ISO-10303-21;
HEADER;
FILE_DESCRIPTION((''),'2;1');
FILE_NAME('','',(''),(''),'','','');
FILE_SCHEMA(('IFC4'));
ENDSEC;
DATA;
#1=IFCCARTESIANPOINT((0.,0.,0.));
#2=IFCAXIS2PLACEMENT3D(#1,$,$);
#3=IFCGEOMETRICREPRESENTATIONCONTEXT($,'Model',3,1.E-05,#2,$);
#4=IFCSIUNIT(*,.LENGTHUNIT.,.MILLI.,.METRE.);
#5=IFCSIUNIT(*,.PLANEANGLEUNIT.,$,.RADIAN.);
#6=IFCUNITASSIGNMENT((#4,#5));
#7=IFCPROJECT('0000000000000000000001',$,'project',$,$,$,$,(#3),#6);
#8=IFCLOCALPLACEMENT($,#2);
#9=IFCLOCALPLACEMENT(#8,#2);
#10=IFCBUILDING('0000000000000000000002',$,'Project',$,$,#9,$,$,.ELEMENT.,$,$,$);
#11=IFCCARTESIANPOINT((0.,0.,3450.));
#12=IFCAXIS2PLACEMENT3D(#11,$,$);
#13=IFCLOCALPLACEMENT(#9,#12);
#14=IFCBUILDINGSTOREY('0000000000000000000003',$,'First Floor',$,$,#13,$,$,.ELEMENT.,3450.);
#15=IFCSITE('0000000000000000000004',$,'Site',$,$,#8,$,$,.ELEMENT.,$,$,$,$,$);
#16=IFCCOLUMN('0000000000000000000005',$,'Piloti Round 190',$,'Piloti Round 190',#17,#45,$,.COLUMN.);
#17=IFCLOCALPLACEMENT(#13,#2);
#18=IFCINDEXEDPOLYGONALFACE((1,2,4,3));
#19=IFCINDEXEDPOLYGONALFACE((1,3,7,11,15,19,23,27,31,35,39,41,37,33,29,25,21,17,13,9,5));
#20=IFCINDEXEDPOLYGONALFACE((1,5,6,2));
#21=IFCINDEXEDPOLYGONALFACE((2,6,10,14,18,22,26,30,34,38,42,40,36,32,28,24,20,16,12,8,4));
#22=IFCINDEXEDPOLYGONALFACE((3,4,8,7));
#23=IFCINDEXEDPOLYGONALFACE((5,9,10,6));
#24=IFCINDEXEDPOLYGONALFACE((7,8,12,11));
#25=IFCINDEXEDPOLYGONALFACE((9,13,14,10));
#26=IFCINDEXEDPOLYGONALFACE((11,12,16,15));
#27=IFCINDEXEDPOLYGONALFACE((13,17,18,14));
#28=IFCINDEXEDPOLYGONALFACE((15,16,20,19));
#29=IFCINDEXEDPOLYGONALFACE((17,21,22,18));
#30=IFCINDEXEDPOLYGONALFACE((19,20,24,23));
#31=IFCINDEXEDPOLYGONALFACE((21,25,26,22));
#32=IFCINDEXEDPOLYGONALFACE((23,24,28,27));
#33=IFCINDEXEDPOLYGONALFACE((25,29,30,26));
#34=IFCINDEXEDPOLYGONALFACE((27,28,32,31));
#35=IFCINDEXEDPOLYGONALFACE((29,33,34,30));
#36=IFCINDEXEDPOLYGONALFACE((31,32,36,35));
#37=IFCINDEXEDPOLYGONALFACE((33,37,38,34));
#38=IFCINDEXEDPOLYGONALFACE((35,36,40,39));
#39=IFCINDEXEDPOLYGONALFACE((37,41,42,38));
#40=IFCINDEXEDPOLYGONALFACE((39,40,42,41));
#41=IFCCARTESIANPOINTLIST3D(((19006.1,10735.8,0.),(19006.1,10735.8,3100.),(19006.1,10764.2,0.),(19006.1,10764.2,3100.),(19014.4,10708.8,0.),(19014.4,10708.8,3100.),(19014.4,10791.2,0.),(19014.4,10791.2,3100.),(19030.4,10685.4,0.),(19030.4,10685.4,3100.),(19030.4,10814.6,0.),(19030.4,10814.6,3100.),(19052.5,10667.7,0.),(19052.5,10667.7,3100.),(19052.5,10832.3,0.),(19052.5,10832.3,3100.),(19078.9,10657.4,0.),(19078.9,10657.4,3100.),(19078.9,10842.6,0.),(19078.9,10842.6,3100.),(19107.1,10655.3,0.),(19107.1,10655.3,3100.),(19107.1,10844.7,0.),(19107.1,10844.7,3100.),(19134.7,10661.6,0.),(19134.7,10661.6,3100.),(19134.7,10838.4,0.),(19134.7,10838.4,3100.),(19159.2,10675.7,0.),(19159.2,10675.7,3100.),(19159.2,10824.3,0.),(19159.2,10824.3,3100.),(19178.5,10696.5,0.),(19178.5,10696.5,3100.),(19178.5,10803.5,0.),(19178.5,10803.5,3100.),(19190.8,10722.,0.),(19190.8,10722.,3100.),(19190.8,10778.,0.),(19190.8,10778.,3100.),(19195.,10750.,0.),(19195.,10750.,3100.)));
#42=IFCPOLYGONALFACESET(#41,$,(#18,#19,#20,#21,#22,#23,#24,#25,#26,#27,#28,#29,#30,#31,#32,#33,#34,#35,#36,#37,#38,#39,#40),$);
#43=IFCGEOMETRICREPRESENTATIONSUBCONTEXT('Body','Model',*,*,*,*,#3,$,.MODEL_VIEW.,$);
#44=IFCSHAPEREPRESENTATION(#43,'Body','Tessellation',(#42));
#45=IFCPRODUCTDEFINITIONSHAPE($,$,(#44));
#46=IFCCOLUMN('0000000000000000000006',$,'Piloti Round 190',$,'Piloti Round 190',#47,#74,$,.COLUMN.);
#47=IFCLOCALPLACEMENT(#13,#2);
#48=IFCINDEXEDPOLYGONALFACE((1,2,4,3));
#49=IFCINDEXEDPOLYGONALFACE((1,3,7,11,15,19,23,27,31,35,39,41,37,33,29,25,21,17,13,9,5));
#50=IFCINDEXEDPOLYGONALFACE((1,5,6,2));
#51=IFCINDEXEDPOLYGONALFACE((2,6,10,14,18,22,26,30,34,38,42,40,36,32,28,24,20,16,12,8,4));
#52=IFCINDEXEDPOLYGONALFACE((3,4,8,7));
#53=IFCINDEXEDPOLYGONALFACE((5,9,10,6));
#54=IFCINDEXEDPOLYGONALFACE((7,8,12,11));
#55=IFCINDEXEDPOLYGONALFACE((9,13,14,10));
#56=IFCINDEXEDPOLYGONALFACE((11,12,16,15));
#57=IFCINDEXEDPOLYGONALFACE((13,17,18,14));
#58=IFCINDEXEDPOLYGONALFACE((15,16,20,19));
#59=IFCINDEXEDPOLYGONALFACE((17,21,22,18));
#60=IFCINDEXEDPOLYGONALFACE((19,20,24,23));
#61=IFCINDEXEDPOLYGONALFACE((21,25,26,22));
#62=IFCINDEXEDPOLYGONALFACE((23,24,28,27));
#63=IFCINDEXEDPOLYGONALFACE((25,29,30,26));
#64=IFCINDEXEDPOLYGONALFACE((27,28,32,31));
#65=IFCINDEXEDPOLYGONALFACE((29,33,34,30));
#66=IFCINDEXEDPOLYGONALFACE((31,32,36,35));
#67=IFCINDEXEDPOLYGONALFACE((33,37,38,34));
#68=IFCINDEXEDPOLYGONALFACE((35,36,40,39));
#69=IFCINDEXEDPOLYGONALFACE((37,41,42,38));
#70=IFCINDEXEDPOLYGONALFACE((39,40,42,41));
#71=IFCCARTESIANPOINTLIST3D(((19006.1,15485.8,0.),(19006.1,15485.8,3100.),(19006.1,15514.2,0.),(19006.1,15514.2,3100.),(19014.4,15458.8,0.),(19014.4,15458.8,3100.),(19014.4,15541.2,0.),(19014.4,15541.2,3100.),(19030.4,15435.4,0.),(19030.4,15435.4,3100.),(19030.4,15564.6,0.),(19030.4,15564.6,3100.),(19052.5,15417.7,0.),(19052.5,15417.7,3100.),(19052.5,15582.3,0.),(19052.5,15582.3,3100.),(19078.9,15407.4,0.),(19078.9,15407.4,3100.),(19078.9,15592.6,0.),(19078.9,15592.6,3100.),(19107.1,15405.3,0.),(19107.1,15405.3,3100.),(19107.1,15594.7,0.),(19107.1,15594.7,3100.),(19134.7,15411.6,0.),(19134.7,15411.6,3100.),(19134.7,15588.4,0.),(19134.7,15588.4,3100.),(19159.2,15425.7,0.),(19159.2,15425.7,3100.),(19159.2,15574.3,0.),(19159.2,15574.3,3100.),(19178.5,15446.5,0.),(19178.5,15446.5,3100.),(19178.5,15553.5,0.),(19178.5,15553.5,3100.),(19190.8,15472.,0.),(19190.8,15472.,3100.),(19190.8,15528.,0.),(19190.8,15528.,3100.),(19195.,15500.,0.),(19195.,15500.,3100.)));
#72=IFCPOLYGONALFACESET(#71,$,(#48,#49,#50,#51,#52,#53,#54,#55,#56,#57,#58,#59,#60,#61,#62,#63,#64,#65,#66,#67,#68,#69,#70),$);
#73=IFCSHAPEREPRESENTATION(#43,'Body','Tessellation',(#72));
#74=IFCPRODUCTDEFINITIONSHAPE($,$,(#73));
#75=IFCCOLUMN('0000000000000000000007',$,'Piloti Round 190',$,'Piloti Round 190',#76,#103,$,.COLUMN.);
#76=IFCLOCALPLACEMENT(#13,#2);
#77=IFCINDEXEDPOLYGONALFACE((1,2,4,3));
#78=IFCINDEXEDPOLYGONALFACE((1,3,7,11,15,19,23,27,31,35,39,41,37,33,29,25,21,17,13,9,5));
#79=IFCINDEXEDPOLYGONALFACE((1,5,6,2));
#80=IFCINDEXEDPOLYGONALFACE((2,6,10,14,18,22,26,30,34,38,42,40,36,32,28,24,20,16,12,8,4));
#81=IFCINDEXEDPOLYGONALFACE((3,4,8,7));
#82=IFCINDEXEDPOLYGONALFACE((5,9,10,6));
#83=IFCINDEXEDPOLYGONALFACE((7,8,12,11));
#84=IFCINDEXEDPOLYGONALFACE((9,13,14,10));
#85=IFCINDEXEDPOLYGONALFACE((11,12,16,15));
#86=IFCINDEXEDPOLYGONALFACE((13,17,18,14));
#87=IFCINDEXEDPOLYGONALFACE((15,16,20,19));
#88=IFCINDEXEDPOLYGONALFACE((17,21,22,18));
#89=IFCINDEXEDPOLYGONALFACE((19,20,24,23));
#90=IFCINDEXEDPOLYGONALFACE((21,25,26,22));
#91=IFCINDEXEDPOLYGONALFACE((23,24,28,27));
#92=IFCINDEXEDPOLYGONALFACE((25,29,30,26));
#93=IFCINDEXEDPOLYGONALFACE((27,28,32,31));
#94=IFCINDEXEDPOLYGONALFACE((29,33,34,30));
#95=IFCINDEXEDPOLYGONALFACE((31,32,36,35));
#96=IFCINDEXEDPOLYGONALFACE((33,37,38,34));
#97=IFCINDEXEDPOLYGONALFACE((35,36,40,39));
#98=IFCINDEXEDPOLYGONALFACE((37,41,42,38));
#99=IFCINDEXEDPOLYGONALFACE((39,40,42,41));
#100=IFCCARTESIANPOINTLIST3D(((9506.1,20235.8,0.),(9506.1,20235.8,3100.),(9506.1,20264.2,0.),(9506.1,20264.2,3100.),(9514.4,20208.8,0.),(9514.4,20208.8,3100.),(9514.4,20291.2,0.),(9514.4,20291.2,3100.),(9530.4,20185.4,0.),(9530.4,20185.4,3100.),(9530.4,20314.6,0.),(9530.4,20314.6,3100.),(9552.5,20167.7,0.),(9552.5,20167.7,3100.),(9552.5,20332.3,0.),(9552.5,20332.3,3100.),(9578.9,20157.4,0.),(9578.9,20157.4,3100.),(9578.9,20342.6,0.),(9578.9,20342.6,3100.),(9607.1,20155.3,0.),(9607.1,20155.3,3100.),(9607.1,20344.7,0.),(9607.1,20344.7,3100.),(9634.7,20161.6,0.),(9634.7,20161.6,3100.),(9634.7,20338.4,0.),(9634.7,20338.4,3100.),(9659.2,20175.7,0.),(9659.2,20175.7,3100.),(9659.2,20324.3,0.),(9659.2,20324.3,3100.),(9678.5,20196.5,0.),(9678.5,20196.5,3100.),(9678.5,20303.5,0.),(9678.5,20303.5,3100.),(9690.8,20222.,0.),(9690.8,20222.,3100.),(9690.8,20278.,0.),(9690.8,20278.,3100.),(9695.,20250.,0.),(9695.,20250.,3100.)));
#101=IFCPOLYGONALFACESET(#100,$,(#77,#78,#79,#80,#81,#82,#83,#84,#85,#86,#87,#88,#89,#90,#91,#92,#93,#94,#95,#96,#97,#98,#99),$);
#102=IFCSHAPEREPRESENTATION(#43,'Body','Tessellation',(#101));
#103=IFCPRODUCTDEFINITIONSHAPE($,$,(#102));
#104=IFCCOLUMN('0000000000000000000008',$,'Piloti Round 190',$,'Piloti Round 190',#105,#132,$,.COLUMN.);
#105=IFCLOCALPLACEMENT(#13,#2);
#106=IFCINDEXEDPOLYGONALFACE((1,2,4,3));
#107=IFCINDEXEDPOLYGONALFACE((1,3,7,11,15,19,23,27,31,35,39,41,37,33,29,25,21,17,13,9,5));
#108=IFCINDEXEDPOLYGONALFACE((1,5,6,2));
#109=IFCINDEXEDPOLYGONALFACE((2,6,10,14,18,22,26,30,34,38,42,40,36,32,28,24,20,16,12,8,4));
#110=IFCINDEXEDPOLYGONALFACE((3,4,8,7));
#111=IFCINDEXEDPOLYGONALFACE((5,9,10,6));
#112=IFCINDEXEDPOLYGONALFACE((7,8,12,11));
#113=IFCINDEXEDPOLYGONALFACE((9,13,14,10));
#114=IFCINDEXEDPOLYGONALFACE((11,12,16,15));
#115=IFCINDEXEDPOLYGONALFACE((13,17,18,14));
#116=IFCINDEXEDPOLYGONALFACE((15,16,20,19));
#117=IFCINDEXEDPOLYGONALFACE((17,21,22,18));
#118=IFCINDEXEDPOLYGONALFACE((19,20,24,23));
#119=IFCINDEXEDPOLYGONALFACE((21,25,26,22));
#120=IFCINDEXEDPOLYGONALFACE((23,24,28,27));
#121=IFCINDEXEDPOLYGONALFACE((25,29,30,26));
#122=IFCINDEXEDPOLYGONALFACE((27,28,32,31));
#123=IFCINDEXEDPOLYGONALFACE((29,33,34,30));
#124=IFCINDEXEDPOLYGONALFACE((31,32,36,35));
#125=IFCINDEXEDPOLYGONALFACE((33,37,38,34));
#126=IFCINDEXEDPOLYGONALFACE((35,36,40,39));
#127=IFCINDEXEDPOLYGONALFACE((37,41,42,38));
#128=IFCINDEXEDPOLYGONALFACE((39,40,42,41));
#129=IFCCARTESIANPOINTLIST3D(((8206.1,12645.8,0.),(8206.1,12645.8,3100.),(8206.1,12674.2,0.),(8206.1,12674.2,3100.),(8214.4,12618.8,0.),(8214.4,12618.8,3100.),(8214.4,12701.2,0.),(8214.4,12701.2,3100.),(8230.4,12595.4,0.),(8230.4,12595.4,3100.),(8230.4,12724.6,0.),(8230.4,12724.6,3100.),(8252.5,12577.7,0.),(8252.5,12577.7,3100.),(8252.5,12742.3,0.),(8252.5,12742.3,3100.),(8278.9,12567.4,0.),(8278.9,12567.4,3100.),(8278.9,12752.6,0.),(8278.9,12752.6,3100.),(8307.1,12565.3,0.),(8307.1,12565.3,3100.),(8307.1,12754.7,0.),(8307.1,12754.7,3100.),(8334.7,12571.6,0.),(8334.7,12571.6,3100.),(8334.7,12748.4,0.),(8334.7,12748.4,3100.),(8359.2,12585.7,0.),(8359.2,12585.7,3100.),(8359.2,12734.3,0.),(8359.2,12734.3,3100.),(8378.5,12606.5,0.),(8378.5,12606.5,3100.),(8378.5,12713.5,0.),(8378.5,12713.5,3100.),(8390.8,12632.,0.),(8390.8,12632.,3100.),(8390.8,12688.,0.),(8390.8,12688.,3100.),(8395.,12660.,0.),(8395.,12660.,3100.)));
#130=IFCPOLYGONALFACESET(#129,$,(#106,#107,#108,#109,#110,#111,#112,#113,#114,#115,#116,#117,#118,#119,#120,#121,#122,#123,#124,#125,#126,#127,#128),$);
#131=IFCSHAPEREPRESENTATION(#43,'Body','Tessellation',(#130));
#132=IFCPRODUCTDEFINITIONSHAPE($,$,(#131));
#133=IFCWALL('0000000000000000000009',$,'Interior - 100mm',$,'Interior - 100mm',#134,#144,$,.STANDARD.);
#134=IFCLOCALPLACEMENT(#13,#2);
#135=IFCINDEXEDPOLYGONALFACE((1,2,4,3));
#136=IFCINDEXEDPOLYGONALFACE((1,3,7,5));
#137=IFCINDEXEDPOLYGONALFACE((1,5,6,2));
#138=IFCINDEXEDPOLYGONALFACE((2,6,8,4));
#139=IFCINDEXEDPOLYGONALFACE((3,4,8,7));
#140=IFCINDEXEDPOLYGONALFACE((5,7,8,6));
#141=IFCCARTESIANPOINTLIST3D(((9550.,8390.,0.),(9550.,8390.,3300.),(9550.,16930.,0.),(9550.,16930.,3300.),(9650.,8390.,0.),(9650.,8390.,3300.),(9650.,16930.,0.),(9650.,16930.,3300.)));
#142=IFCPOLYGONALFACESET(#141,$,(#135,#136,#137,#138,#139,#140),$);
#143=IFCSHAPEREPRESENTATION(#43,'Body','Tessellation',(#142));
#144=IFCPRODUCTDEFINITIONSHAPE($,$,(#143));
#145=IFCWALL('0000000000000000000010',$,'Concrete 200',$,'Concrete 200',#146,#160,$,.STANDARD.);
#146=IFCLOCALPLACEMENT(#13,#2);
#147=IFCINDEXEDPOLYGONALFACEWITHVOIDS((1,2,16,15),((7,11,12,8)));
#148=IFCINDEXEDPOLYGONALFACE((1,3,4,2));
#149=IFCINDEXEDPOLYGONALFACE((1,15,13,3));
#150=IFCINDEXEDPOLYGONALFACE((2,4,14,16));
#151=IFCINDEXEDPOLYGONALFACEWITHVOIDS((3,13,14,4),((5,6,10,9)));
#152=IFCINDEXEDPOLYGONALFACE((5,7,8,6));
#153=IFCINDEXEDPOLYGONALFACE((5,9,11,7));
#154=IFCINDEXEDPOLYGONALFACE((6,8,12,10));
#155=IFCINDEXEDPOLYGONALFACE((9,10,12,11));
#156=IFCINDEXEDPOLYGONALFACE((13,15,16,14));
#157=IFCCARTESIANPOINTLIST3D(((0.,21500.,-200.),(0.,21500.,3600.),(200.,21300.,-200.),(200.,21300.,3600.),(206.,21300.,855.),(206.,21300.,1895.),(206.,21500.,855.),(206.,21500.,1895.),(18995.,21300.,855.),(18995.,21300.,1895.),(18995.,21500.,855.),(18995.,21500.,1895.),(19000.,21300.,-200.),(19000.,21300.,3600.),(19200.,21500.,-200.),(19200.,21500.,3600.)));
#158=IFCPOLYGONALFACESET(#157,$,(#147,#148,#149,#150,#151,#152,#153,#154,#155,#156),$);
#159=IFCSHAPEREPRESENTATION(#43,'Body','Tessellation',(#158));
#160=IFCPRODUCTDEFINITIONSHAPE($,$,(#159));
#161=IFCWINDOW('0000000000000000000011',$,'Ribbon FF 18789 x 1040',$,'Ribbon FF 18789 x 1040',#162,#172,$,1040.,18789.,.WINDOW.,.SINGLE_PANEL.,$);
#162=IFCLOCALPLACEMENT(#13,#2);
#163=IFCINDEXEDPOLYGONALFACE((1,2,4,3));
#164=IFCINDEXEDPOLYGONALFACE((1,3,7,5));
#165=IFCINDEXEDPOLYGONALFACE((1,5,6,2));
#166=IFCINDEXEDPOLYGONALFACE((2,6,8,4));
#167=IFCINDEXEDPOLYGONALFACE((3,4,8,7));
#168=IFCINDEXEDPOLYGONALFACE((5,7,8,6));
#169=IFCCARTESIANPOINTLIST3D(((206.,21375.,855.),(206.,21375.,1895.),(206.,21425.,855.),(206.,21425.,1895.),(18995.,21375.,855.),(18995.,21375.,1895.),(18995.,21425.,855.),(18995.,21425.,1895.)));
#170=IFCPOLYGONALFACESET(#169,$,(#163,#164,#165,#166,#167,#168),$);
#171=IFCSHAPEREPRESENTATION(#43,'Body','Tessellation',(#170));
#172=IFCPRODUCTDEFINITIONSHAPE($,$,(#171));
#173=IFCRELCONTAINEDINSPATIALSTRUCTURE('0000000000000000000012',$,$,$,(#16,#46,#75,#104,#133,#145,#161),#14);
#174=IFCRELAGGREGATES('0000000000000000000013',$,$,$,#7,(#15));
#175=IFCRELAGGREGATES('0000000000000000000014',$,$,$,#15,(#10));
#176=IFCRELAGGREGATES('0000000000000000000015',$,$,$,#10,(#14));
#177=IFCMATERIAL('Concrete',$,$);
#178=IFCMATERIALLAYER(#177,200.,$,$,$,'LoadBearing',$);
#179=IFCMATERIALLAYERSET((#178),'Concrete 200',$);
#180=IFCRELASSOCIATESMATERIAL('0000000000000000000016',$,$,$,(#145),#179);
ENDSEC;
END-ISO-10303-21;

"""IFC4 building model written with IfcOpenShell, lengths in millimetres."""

from ifc_helpers import new_model, si_unit, frame, frame_2d, origin, origin_2d, place, context, subcontext, project, spatial, polyline, rectangle, circle, outline, extrude, material, layer, layer_set, layer_usage, element, fill, save


model = new_model("IFC4")

# Units and contexts
model_context = context("Model", 3, precision=1e-05, world=origin())
body_context = subcontext(model_context, "Body", "Model", "MODEL_VIEW")
ifc_project = project(units=[si_unit("LENGTHUNIT", "METRE", prefix="MILLI"), si_unit("PLANEANGLEUNIT", "RADIAN")], contexts=[model_context])

# Site, building, storey
site_placement = place(None, origin())
site = spatial("IfcSite", under=ifc_project, at=site_placement, Name="Site", CompositionType="ELEMENT")
building_placement = place(site_placement, origin())
building = spatial("IfcBuilding", under=site, at=building_placement, Name="Project", CompositionType="ELEMENT")
storey_placement = place(building_placement, frame((0.0, 0.0, 3450.0)))
storey = spatial("IfcBuildingStorey", under=building, at=storey_placement, Name="First Floor", CompositionType="ELEMENT", Elevation=3450.0)

# Columns
for number, where, z_axis, x_axis, name in (
    (1, (19100.0, 10750.0, 0.0), (0.0, 0.0, 1.0), (1.0, 0.0, 0.0), "Piloti Round 190"),
    (2, (19100.0, 15500.0, 0.0), (0.0, 0.0, 1.0), (1.0, 0.0, 0.0), "Piloti Round 190"),
    (3, (9600.0, 20250.0, 0.0), (0.0, 0.0, 1.0), (1.0, 0.0, 0.0), "Piloti Round 190"),
    (4, (8300.0, 12660.0, 0.0), (0.0, 0.0, 1.0), (1.0, 0.0, 0.0), "Piloti Round 190"),
):
    element("IfcColumn", number, at=place(storey_placement, frame(where, z_axis=z_axis, x_axis=x_axis)), inside=storey, Name=name, ObjectType="Piloti Round 190", PredefinedType="COLUMN", context=body_context, shape_type="SweptSolid", body=[
        extrude(circle(Radius=95.0, at=origin_2d()), origin(), (0.0, 0.0, 1.0), 3100.0),
    ])

# Wall
wall_1_placement = place(storey_placement, frame((9600.0, 8390.0, 0.0), z_axis=(0.0, 0.0, 1.0), x_axis=(0.0, 1.0, 0.0)))
element("IfcWall", 5, at=wall_1_placement, inside=storey, Name="Interior - 100mm", ObjectType="Interior - 100mm", PredefinedType="STANDARD", context=body_context, shape_type="SweptSolid", body=[
    extrude(outline(polyline([(0.0, -50.0), (0.0, 50.0), (8540.0, 50.0), (8540.0, -50.0), (0.0, -50.0)])), origin(), (0.0, 0.0, 1.0), 3300.0),
])

# Wall, opening, window
ifc_material = material(Name="Concrete")
ifc_layer = layer(ifc_material, 200.0, Category="LoadBearing")
ifc_layer_set = layer_set([ifc_layer], Name="Concrete 200")
ifc_layer_usage = layer_usage(ifc_layer_set, "AXIS2", "NEGATIVE", 100.0)
wall_2_placement = place(storey_placement, frame((100.0, 21400.0, -200.0), z_axis=(0.0, 0.0, 1.0), x_axis=(1.0, 0.0, 0.0)))
wall_2 = element("IfcWall", 6, at=wall_2_placement, inside=storey, material=ifc_layer_usage, Name="Concrete 200", ObjectType="Concrete 200", PredefinedType="STANDARD", context=body_context, shape_type="SweptSolid", body=[
    extrude(outline(polyline([(100.0, -100.0), (0.0, 0.0), (-100.0, 100.0), (19100.0, 100.0), (19000.0, 0.0), (18900.0, -100.0), (100.0, -100.0)])), origin(), (0.0, 0.0, 1.0), 3800.0),
])
opening_1_placement = place(wall_2_placement, frame((106.0, 0.0, 1055.0), z_axis=(0.0, 0.0, 1.0), x_axis=(1.0, 0.0, 0.0)))
opening_1 = element("IfcOpeningElement", 7, at=opening_1_placement, cuts=wall_2, PredefinedType="OPENING", context=body_context, shape_type="SweptSolid", body=[
    extrude(rectangle(XDim=18789.0, YDim=220.0, at=frame_2d((9394.5, 0.0))), origin(), (0.0, 0.0, 1.0), 1040.0),
])
window_1_placement = place(opening_1_placement, origin())
window_1 = element("IfcWindow", 8, at=window_1_placement, inside=storey, Name="Ribbon FF 18789 x 1040", ObjectType="Ribbon FF 18789 x 1040", OverallHeight=1040.0, OverallWidth=18789.0, PartitioningType="SINGLE_PANEL", PredefinedType="WINDOW", context=body_context, shape_type="SweptSolid", body=[
    extrude(rectangle(XDim=18789.0, YDim=50.0, at=frame_2d((9394.5, 0.0))), origin(), (0.0, 0.0, 1.0), 1040.0),
])
fill(opening_1, window_1)

save(model, "model.ifc")
